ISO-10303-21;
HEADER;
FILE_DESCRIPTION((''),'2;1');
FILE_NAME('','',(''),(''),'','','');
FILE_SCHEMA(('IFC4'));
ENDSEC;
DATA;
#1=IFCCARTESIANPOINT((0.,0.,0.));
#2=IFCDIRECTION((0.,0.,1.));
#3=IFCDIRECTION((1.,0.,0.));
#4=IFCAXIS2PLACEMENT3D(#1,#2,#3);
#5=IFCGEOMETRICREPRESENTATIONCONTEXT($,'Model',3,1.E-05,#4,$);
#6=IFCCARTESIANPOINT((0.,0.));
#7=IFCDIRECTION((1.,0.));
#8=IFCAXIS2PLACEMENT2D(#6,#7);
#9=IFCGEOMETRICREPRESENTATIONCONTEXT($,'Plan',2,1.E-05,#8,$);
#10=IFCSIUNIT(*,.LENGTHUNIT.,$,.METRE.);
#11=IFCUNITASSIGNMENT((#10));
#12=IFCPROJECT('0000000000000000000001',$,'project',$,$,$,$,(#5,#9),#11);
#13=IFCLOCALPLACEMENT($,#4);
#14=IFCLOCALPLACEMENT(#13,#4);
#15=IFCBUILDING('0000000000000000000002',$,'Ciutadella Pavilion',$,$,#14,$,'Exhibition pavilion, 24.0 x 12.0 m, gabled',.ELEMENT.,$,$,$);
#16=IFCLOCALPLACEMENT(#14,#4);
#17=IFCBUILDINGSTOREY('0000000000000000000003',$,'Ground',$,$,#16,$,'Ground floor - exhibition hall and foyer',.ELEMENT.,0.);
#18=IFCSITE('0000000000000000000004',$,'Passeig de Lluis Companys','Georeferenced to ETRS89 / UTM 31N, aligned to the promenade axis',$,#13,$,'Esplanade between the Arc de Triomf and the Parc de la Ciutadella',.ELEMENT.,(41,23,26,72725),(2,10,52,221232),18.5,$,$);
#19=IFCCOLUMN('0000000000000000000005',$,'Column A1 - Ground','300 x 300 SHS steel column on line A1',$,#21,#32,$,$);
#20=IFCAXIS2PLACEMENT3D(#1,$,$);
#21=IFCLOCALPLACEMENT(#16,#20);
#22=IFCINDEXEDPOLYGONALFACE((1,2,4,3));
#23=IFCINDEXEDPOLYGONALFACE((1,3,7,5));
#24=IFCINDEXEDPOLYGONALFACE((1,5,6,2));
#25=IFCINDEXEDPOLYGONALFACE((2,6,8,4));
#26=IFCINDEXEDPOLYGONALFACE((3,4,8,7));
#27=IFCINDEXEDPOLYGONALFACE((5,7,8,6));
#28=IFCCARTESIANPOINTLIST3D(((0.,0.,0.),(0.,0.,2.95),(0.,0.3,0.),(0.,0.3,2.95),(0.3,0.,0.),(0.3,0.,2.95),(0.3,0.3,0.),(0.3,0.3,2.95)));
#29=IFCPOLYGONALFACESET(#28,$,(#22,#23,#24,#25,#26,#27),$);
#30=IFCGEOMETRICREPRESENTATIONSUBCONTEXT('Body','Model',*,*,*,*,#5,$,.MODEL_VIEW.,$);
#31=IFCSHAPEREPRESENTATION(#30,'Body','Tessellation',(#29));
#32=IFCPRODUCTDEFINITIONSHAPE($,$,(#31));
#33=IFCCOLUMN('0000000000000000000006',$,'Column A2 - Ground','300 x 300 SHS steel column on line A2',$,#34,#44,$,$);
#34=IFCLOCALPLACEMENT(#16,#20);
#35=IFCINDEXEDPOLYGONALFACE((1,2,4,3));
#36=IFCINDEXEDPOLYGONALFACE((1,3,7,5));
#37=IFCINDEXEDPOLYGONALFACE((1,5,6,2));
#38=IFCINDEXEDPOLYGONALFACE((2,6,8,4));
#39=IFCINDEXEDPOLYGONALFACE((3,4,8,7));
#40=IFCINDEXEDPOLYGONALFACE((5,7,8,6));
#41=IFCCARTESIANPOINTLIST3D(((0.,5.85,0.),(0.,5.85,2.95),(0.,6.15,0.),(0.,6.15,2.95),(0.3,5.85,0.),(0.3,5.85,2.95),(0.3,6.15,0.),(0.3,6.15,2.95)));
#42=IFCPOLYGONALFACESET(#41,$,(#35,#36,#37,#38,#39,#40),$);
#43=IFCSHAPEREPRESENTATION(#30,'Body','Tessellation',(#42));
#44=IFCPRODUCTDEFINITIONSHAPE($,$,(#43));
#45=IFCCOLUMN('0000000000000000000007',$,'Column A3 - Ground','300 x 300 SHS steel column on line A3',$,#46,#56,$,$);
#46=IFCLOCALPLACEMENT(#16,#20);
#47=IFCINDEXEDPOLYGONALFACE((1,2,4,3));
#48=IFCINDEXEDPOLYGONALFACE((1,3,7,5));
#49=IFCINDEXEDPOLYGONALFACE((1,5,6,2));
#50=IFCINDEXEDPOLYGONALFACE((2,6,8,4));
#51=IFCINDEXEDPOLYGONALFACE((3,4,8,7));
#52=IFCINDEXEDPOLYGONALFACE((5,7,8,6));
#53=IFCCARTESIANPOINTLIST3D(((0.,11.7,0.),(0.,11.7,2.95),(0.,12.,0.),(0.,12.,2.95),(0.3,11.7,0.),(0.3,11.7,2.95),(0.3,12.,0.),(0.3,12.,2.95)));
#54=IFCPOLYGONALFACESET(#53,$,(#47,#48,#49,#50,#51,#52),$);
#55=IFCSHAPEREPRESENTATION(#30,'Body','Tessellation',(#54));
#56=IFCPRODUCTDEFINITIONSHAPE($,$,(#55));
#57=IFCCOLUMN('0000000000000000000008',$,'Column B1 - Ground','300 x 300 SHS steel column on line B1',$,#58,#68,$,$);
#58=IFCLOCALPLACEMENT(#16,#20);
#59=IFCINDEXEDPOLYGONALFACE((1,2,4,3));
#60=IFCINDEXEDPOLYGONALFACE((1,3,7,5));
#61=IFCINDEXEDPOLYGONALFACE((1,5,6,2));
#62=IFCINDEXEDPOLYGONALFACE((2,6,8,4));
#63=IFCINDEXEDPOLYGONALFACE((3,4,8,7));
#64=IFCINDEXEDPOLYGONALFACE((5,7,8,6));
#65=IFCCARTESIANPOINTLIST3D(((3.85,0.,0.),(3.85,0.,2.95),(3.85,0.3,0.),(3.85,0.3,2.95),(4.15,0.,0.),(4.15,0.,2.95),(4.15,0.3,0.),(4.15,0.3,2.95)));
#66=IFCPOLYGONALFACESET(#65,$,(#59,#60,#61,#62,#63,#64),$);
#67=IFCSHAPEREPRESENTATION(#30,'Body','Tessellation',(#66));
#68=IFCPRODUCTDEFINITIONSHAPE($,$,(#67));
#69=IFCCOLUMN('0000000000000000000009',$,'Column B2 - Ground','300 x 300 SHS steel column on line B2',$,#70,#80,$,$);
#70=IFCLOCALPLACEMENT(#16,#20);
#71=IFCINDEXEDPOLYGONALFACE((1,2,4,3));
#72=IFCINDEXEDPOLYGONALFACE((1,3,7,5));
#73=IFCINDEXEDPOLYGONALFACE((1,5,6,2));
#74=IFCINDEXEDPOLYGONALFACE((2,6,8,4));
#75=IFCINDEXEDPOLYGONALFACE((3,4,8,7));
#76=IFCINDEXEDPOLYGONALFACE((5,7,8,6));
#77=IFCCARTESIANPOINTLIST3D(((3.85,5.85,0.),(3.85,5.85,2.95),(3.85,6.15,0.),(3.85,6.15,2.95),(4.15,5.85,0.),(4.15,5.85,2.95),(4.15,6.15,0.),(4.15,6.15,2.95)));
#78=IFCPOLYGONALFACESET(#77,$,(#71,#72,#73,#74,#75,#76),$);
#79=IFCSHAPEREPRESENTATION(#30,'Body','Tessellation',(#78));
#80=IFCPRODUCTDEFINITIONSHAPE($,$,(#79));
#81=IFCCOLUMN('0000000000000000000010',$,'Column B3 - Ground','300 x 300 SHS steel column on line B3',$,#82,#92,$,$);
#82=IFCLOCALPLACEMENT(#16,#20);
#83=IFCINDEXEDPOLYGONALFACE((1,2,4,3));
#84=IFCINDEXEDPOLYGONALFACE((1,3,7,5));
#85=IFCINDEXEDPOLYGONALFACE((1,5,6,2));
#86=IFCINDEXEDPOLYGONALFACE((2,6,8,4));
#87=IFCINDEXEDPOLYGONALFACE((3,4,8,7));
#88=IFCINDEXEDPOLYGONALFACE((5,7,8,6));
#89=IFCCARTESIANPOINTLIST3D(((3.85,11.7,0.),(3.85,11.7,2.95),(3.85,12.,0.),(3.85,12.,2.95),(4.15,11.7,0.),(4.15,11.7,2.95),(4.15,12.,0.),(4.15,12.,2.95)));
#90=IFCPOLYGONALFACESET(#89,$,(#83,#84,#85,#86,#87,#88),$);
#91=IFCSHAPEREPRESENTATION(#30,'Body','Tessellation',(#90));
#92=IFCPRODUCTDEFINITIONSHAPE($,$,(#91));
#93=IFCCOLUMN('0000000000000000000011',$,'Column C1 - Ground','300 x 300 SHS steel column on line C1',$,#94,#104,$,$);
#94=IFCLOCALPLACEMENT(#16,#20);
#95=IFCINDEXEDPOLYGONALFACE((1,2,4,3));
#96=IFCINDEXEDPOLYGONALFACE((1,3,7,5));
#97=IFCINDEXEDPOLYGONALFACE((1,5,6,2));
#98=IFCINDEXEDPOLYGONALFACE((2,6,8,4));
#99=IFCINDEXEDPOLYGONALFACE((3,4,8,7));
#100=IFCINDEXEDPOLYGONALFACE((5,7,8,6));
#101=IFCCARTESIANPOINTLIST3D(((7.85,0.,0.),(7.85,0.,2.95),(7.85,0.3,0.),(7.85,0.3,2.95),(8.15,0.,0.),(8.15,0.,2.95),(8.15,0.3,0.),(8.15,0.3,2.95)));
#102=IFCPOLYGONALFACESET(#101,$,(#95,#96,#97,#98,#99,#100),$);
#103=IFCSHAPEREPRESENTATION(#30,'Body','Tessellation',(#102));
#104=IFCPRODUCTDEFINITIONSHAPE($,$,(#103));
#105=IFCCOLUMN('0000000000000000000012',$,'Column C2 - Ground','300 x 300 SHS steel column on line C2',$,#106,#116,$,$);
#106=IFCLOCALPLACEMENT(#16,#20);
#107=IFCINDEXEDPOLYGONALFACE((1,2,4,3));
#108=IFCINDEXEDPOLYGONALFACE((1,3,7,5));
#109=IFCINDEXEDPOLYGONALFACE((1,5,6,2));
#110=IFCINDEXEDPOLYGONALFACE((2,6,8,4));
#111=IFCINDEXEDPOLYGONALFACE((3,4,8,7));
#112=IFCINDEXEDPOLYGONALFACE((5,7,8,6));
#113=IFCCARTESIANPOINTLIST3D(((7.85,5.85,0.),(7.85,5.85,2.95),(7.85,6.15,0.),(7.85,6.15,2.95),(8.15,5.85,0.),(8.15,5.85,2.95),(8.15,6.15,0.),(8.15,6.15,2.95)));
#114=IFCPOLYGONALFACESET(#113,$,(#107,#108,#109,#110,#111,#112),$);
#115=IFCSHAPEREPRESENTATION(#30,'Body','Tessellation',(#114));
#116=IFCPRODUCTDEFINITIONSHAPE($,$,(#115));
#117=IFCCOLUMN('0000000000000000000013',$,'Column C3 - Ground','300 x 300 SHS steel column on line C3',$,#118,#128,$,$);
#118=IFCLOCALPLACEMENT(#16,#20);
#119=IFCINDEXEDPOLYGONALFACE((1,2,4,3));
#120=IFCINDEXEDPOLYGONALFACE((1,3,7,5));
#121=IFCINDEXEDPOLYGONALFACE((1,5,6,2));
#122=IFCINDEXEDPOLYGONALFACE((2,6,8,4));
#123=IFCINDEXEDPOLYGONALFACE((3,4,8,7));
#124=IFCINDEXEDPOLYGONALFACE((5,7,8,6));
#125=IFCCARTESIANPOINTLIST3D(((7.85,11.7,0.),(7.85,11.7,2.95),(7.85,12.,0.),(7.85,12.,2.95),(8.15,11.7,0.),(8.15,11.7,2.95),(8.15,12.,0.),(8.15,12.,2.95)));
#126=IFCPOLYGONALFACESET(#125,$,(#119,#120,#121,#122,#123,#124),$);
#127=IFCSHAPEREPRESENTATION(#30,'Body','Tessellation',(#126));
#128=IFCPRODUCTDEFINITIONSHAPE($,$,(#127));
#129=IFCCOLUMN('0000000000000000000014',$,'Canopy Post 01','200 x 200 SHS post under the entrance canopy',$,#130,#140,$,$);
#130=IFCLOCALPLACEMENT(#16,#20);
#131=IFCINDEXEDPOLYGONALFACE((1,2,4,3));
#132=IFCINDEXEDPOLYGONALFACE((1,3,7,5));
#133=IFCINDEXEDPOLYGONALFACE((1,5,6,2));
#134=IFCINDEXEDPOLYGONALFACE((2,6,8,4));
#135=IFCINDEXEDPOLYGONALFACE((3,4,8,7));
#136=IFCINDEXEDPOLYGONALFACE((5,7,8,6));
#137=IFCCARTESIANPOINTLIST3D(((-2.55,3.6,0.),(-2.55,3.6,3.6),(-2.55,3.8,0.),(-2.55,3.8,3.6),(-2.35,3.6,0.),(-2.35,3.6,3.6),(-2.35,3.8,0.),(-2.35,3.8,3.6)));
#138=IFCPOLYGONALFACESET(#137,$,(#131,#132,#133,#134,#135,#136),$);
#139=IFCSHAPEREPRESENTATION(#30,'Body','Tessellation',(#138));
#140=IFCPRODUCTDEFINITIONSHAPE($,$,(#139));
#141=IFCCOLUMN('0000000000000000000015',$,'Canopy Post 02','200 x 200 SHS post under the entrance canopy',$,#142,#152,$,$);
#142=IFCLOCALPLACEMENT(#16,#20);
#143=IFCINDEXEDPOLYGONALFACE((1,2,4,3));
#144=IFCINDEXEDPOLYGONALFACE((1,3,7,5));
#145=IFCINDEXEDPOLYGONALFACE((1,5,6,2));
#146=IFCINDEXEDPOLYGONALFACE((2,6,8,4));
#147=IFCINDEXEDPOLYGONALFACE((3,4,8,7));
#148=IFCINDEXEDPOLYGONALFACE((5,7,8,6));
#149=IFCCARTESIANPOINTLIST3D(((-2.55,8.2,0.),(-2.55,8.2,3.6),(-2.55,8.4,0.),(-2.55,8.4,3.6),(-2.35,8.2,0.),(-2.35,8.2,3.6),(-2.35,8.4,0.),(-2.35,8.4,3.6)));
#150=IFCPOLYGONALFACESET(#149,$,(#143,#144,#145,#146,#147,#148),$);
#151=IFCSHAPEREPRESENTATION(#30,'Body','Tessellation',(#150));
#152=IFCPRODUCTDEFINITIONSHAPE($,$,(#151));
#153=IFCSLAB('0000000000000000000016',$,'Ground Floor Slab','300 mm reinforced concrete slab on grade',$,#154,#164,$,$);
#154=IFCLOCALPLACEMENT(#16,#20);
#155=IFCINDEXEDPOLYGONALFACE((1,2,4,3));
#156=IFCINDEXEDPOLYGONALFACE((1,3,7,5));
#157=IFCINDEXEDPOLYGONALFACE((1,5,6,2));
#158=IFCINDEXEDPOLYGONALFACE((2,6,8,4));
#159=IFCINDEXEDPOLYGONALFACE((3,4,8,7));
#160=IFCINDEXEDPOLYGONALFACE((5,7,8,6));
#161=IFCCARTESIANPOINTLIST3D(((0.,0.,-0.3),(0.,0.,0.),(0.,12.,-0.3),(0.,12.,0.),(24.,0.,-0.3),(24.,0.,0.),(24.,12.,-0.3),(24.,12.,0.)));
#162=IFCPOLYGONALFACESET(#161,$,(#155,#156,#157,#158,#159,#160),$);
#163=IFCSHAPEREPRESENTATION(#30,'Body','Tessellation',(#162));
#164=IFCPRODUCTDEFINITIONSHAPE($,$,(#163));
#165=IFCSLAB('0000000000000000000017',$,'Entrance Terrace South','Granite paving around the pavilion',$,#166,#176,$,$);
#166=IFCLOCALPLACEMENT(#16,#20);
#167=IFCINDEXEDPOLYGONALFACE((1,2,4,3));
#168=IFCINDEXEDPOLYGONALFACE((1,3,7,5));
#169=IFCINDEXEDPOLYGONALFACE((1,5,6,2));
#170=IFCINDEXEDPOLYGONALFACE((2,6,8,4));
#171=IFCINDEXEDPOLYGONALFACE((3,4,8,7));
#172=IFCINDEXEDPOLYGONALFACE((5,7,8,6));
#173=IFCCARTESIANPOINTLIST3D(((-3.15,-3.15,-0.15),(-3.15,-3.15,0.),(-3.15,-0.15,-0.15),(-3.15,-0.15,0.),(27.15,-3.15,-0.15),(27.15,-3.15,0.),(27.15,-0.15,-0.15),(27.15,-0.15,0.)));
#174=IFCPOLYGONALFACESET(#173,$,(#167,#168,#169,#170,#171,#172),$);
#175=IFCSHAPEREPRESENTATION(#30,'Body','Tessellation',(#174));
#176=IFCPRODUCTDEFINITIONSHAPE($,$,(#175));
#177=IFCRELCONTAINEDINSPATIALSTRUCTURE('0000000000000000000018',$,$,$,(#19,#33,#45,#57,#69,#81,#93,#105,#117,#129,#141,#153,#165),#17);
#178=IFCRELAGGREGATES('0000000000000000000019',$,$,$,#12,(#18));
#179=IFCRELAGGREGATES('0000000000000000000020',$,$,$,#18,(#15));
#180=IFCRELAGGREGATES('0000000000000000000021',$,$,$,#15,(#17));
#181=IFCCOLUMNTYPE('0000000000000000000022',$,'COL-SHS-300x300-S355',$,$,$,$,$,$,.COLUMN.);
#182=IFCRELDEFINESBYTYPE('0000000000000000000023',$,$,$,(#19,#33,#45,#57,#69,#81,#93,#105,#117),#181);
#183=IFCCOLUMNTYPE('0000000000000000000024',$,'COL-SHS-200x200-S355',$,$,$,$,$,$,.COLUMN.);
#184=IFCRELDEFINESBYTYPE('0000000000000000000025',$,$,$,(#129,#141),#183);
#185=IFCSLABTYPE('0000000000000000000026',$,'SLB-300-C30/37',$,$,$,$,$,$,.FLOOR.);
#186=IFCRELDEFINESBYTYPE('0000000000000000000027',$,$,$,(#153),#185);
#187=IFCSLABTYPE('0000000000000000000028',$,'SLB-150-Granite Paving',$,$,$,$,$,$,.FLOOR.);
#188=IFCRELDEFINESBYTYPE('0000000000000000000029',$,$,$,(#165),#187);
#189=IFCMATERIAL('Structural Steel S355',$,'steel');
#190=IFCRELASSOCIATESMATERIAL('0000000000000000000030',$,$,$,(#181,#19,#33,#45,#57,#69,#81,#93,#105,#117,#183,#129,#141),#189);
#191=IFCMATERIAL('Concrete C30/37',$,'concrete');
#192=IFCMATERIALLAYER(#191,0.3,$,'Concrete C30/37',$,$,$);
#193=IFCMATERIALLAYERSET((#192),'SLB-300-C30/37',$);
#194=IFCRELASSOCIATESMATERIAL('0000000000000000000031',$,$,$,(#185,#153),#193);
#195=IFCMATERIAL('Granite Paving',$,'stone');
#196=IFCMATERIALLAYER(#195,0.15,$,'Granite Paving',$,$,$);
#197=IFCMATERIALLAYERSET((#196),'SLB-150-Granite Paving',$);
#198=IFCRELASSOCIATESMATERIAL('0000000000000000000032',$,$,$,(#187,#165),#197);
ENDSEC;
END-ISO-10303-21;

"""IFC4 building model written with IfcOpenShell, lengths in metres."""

from ifc_helpers import new_model, si_unit, frame, origin_with_axes, origin_2d_with_axis, place, context, subcontext, project, spatial, line, indexed_curve, rectangle, outline, extrude, material, layer, layer_set, layer_usage, material_profile, profile_set, profile_usage, type_object, element, save


model = new_model("IFC4")

# Units and contexts
model_context = context("Model", 3, precision=1e-05, world=origin_with_axes())
plan_context = context("Plan", 2, precision=1e-05, world=origin_2d_with_axis())
body_context = subcontext(model_context, "Body", "Model", "MODEL_VIEW")
ifc_project = project(units=[si_unit("LENGTHUNIT", "METRE")], contexts=[model_context, plan_context])

# Site, building, storey
site_placement = place(None, origin_with_axes())
site = spatial("IfcSite", under=ifc_project, at=site_placement, Name="Passeig de Lluis Companys", Description="Georeferenced to ETRS89 / UTM 31N, aligned to the promenade axis", LongName="Esplanade between the Arc de Triomf and the Parc de la Ciutadella", CompositionType="ELEMENT", RefLatitude=(41, 23, 26, 72725), RefLongitude=(2, 10, 52, 221232), RefElevation=18.5)
building_placement = place(site_placement, origin_with_axes())
building = spatial("IfcBuilding", under=site, at=building_placement, Name="Ciutadella Pavilion", LongName="Exhibition pavilion, 24.0 x 12.0 m, gabled", CompositionType="ELEMENT")
storey_placement = place(building_placement, origin_with_axes())
storey = spatial("IfcBuildingStorey", under=building, at=storey_placement, Name="Ground", LongName="Ground floor - exhibition hall and foyer", CompositionType="ELEMENT", Elevation=0.0)

# Columns
ifc_material_1 = material(Name="Structural Steel S355", Category="steel")
ifc_material_profile_1 = material_profile(ifc_material_1, rectangle(XDim=0.3, YDim=0.3))
ifc_profile_set_1 = profile_set([ifc_material_profile_1], Name="COL-SHS-300x300-S355")
ifc_profile_usage_1 = profile_usage(ifc_profile_set_1)
column_type_1 = type_object("IfcColumnType", Name="COL-SHS-300x300-S355", PredefinedType="COLUMN", material=ifc_profile_set_1)
column_1_placement = place(storey_placement, origin_with_axes())
element("IfcColumn", 1, at=column_1_placement, inside=storey, type_object=column_type_1, material=ifc_profile_usage_1, Name="Column A1 - Ground", Description="300 x 300 SHS steel column on line A1", context=body_context, shape_type="SweptSolid", body=[
    extrude(outline(indexed_curve([(0.0, 0.0), (0.3, 0.0), (0.3, 0.3), (0.0, 0.3)], segments=[line(1, 2, 3, 4, 1)])), origin_with_axes(), (0.0, 0.0, 1.0), 2.95),
])
ifc_profile_usage_2 = profile_usage(ifc_profile_set_1)
column_2_placement = place(storey_placement, frame((0.0, 5.85, 0.0), z_axis=(0.0, 0.0, 1.0), x_axis=(1.0, 0.0, 0.0)))
element("IfcColumn", 2, at=column_2_placement, inside=storey, type_object=column_type_1, material=ifc_profile_usage_2, Name="Column A2 - Ground", Description="300 x 300 SHS steel column on line A2", context=body_context, shape_type="SweptSolid", body=[
    extrude(outline(indexed_curve([(0.0, 0.0), (0.3, 0.0), (0.3, 0.3), (0.0, 0.3)], segments=[line(1, 2, 3, 4, 1)])), origin_with_axes(), (0.0, 0.0, 1.0), 2.95),
])
ifc_profile_usage_3 = profile_usage(ifc_profile_set_1)
column_3_placement = place(storey_placement, frame((0.0, 11.7, 0.0), z_axis=(0.0, 0.0, 1.0), x_axis=(1.0, 0.0, 0.0)))
element("IfcColumn", 3, at=column_3_placement, inside=storey, type_object=column_type_1, material=ifc_profile_usage_3, Name="Column A3 - Ground", Description="300 x 300 SHS steel column on line A3", context=body_context, shape_type="SweptSolid", body=[
    extrude(outline(indexed_curve([(0.0, 0.0), (0.3, 0.0), (0.3, 0.3), (0.0, 0.3)], segments=[line(1, 2, 3, 4, 1)])), origin_with_axes(), (0.0, 0.0, 1.0), 2.95),
])
ifc_profile_usage_4 = profile_usage(ifc_profile_set_1)
column_4_placement = place(storey_placement, frame((3.85, 0.0, 0.0), z_axis=(0.0, 0.0, 1.0), x_axis=(1.0, 0.0, 0.0)))
element("IfcColumn", 4, at=column_4_placement, inside=storey, type_object=column_type_1, material=ifc_profile_usage_4, Name="Column B1 - Ground", Description="300 x 300 SHS steel column on line B1", context=body_context, shape_type="SweptSolid", body=[
    extrude(outline(indexed_curve([(0.0, 0.0), (0.3, 0.0), (0.3, 0.3), (0.0, 0.3)], segments=[line(1, 2, 3, 4, 1)])), origin_with_axes(), (0.0, 0.0, 1.0), 2.95),
])
ifc_profile_usage_5 = profile_usage(ifc_profile_set_1)
column_5_placement = place(storey_placement, frame((3.85, 5.85, 0.0), z_axis=(0.0, 0.0, 1.0), x_axis=(1.0, 0.0, 0.0)))
element("IfcColumn", 5, at=column_5_placement, inside=storey, type_object=column_type_1, material=ifc_profile_usage_5, Name="Column B2 - Ground", Description="300 x 300 SHS steel column on line B2", context=body_context, shape_type="SweptSolid", body=[
    extrude(outline(indexed_curve([(0.0, 0.0), (0.3, 0.0), (0.3, 0.3), (0.0, 0.3)], segments=[line(1, 2, 3, 4, 1)])), origin_with_axes(), (0.0, 0.0, 1.0), 2.95),
])
ifc_profile_usage_6 = profile_usage(ifc_profile_set_1)
column_6_placement = place(storey_placement, frame((3.85, 11.7, 0.0), z_axis=(0.0, 0.0, 1.0), x_axis=(1.0, 0.0, 0.0)))
element("IfcColumn", 6, at=column_6_placement, inside=storey, type_object=column_type_1, material=ifc_profile_usage_6, Name="Column B3 - Ground", Description="300 x 300 SHS steel column on line B3", context=body_context, shape_type="SweptSolid", body=[
    extrude(outline(indexed_curve([(0.0, 0.0), (0.3, 0.0), (0.3, 0.3), (0.0, 0.3)], segments=[line(1, 2, 3, 4, 1)])), origin_with_axes(), (0.0, 0.0, 1.0), 2.95),
])
ifc_profile_usage_7 = profile_usage(ifc_profile_set_1)
column_7_placement = place(storey_placement, frame((7.85, 0.0, 0.0), z_axis=(0.0, 0.0, 1.0), x_axis=(1.0, 0.0, 0.0)))
element("IfcColumn", 7, at=column_7_placement, inside=storey, type_object=column_type_1, material=ifc_profile_usage_7, Name="Column C1 - Ground", Description="300 x 300 SHS steel column on line C1", context=body_context, shape_type="SweptSolid", body=[
    extrude(outline(indexed_curve([(0.0, 0.0), (0.3, 0.0), (0.3, 0.3), (0.0, 0.3)], segments=[line(1, 2, 3, 4, 1)])), origin_with_axes(), (0.0, 0.0, 1.0), 2.95),
])
ifc_profile_usage_8 = profile_usage(ifc_profile_set_1)
column_8_placement = place(storey_placement, frame((7.85, 5.85, 0.0), z_axis=(0.0, 0.0, 1.0), x_axis=(1.0, 0.0, 0.0)))
element("IfcColumn", 8, at=column_8_placement, inside=storey, type_object=column_type_1, material=ifc_profile_usage_8, Name="Column C2 - Ground", Description="300 x 300 SHS steel column on line C2", context=body_context, shape_type="SweptSolid", body=[
    extrude(outline(indexed_curve([(0.0, 0.0), (0.3, 0.0), (0.3, 0.3), (0.0, 0.3)], segments=[line(1, 2, 3, 4, 1)])), origin_with_axes(), (0.0, 0.0, 1.0), 2.95),
])
ifc_profile_usage_9 = profile_usage(ifc_profile_set_1)
column_9_placement = place(storey_placement, frame((7.85, 11.7, 0.0), z_axis=(0.0, 0.0, 1.0), x_axis=(1.0, 0.0, 0.0)))
element("IfcColumn", 9, at=column_9_placement, inside=storey, type_object=column_type_1, material=ifc_profile_usage_9, Name="Column C3 - Ground", Description="300 x 300 SHS steel column on line C3", context=body_context, shape_type="SweptSolid", body=[
    extrude(outline(indexed_curve([(0.0, 0.0), (0.3, 0.0), (0.3, 0.3), (0.0, 0.3)], segments=[line(1, 2, 3, 4, 1)])), origin_with_axes(), (0.0, 0.0, 1.0), 2.95),
])
ifc_material_profile_2 = material_profile(ifc_material_1, rectangle(XDim=0.2, YDim=0.2))
ifc_profile_set_2 = profile_set([ifc_material_profile_2], Name="COL-SHS-200x200-S355")
ifc_profile_usage_10 = profile_usage(ifc_profile_set_2)
column_type_2 = type_object("IfcColumnType", Name="COL-SHS-200x200-S355", PredefinedType="COLUMN", material=ifc_profile_set_2)
column_10_placement = place(storey_placement, frame((-2.55, 3.6, 0.0), z_axis=(0.0, 0.0, 1.0), x_axis=(1.0, 0.0, 0.0)))
element("IfcColumn", 10, at=column_10_placement, inside=storey, type_object=column_type_2, material=ifc_profile_usage_10, Name="Canopy Post 01", Description="200 x 200 SHS post under the entrance canopy", context=body_context, shape_type="SweptSolid", body=[
    extrude(outline(indexed_curve([(0.0, 0.0), (0.2, 0.0), (0.2, 0.2), (0.0, 0.2)], segments=[line(1, 2, 3, 4, 1)])), origin_with_axes(), (0.0, 0.0, 1.0), 3.6),
])
ifc_profile_usage_11 = profile_usage(ifc_profile_set_2)
column_11_placement = place(storey_placement, frame((-2.55, 8.2, 0.0), z_axis=(0.0, 0.0, 1.0), x_axis=(1.0, 0.0, 0.0)))
element("IfcColumn", 11, at=column_11_placement, inside=storey, type_object=column_type_2, material=ifc_profile_usage_11, Name="Canopy Post 02", Description="200 x 200 SHS post under the entrance canopy", context=body_context, shape_type="SweptSolid", body=[
    extrude(outline(indexed_curve([(0.0, 0.0), (0.2, 0.0), (0.2, 0.2), (0.0, 0.2)], segments=[line(1, 2, 3, 4, 1)])), origin_with_axes(), (0.0, 0.0, 1.0), 3.6),
])

# Slabs
ifc_material_2 = material(Name="Concrete C30/37", Category="concrete")
ifc_layer_1 = layer(ifc_material_2, 0.3, Name="Concrete C30/37")
ifc_layer_set_1 = layer_set([ifc_layer_1], Name="SLB-300-C30/37")
ifc_layer_usage_1 = layer_usage(ifc_layer_set_1, "AXIS3", "POSITIVE", 0.0)
slab_type_1 = type_object("IfcSlabType", Name="SLB-300-C30/37", PredefinedType="FLOOR", material=ifc_layer_set_1)
slab_1_placement = place(storey_placement, frame((0.0, 0.0, -0.3), z_axis=(0.0, 0.0, 1.0), x_axis=(1.0, 0.0, 0.0)))
element("IfcSlab", 12, at=slab_1_placement, inside=storey, type_object=slab_type_1, material=ifc_layer_usage_1, Name="Ground Floor Slab", Description="300 mm reinforced concrete slab on grade", context=body_context, shape_type="SweptSolid", body=[
    extrude(outline(indexed_curve([(0.0, 0.0), (24.0, 0.0), (24.0, 12.0), (0.0, 12.0)], segments=[line(1, 2, 3, 4, 1)])), origin_with_axes(), (0.0, 0.0, 1.0), 0.3),
])
ifc_material_3 = material(Name="Granite Paving", Category="stone")
ifc_layer_2 = layer(ifc_material_3, 0.15, Name="Granite Paving")
ifc_layer_set_2 = layer_set([ifc_layer_2], Name="SLB-150-Granite Paving")
ifc_layer_usage_2 = layer_usage(ifc_layer_set_2, "AXIS3", "POSITIVE", 0.0)
slab_type_2 = type_object("IfcSlabType", Name="SLB-150-Granite Paving", PredefinedType="FLOOR", material=ifc_layer_set_2)
slab_2_placement = place(storey_placement, frame((-3.15, -3.15, -0.15), z_axis=(0.0, 0.0, 1.0), x_axis=(1.0, 0.0, 0.0)))
element("IfcSlab", 13, at=slab_2_placement, inside=storey, type_object=slab_type_2, material=ifc_layer_usage_2, Name="Entrance Terrace South", Description="Granite paving around the pavilion", context=body_context, shape_type="SweptSolid", body=[
    extrude(outline(indexed_curve([(0.0, 0.0), (30.3, 0.0), (30.3, 3.0), (0.0, 3.0)], segments=[line(1, 2, 3, 4, 1)])), origin_with_axes(), (0.0, 0.0, 1.0), 0.15),
])

save(model, "model.ifc")
